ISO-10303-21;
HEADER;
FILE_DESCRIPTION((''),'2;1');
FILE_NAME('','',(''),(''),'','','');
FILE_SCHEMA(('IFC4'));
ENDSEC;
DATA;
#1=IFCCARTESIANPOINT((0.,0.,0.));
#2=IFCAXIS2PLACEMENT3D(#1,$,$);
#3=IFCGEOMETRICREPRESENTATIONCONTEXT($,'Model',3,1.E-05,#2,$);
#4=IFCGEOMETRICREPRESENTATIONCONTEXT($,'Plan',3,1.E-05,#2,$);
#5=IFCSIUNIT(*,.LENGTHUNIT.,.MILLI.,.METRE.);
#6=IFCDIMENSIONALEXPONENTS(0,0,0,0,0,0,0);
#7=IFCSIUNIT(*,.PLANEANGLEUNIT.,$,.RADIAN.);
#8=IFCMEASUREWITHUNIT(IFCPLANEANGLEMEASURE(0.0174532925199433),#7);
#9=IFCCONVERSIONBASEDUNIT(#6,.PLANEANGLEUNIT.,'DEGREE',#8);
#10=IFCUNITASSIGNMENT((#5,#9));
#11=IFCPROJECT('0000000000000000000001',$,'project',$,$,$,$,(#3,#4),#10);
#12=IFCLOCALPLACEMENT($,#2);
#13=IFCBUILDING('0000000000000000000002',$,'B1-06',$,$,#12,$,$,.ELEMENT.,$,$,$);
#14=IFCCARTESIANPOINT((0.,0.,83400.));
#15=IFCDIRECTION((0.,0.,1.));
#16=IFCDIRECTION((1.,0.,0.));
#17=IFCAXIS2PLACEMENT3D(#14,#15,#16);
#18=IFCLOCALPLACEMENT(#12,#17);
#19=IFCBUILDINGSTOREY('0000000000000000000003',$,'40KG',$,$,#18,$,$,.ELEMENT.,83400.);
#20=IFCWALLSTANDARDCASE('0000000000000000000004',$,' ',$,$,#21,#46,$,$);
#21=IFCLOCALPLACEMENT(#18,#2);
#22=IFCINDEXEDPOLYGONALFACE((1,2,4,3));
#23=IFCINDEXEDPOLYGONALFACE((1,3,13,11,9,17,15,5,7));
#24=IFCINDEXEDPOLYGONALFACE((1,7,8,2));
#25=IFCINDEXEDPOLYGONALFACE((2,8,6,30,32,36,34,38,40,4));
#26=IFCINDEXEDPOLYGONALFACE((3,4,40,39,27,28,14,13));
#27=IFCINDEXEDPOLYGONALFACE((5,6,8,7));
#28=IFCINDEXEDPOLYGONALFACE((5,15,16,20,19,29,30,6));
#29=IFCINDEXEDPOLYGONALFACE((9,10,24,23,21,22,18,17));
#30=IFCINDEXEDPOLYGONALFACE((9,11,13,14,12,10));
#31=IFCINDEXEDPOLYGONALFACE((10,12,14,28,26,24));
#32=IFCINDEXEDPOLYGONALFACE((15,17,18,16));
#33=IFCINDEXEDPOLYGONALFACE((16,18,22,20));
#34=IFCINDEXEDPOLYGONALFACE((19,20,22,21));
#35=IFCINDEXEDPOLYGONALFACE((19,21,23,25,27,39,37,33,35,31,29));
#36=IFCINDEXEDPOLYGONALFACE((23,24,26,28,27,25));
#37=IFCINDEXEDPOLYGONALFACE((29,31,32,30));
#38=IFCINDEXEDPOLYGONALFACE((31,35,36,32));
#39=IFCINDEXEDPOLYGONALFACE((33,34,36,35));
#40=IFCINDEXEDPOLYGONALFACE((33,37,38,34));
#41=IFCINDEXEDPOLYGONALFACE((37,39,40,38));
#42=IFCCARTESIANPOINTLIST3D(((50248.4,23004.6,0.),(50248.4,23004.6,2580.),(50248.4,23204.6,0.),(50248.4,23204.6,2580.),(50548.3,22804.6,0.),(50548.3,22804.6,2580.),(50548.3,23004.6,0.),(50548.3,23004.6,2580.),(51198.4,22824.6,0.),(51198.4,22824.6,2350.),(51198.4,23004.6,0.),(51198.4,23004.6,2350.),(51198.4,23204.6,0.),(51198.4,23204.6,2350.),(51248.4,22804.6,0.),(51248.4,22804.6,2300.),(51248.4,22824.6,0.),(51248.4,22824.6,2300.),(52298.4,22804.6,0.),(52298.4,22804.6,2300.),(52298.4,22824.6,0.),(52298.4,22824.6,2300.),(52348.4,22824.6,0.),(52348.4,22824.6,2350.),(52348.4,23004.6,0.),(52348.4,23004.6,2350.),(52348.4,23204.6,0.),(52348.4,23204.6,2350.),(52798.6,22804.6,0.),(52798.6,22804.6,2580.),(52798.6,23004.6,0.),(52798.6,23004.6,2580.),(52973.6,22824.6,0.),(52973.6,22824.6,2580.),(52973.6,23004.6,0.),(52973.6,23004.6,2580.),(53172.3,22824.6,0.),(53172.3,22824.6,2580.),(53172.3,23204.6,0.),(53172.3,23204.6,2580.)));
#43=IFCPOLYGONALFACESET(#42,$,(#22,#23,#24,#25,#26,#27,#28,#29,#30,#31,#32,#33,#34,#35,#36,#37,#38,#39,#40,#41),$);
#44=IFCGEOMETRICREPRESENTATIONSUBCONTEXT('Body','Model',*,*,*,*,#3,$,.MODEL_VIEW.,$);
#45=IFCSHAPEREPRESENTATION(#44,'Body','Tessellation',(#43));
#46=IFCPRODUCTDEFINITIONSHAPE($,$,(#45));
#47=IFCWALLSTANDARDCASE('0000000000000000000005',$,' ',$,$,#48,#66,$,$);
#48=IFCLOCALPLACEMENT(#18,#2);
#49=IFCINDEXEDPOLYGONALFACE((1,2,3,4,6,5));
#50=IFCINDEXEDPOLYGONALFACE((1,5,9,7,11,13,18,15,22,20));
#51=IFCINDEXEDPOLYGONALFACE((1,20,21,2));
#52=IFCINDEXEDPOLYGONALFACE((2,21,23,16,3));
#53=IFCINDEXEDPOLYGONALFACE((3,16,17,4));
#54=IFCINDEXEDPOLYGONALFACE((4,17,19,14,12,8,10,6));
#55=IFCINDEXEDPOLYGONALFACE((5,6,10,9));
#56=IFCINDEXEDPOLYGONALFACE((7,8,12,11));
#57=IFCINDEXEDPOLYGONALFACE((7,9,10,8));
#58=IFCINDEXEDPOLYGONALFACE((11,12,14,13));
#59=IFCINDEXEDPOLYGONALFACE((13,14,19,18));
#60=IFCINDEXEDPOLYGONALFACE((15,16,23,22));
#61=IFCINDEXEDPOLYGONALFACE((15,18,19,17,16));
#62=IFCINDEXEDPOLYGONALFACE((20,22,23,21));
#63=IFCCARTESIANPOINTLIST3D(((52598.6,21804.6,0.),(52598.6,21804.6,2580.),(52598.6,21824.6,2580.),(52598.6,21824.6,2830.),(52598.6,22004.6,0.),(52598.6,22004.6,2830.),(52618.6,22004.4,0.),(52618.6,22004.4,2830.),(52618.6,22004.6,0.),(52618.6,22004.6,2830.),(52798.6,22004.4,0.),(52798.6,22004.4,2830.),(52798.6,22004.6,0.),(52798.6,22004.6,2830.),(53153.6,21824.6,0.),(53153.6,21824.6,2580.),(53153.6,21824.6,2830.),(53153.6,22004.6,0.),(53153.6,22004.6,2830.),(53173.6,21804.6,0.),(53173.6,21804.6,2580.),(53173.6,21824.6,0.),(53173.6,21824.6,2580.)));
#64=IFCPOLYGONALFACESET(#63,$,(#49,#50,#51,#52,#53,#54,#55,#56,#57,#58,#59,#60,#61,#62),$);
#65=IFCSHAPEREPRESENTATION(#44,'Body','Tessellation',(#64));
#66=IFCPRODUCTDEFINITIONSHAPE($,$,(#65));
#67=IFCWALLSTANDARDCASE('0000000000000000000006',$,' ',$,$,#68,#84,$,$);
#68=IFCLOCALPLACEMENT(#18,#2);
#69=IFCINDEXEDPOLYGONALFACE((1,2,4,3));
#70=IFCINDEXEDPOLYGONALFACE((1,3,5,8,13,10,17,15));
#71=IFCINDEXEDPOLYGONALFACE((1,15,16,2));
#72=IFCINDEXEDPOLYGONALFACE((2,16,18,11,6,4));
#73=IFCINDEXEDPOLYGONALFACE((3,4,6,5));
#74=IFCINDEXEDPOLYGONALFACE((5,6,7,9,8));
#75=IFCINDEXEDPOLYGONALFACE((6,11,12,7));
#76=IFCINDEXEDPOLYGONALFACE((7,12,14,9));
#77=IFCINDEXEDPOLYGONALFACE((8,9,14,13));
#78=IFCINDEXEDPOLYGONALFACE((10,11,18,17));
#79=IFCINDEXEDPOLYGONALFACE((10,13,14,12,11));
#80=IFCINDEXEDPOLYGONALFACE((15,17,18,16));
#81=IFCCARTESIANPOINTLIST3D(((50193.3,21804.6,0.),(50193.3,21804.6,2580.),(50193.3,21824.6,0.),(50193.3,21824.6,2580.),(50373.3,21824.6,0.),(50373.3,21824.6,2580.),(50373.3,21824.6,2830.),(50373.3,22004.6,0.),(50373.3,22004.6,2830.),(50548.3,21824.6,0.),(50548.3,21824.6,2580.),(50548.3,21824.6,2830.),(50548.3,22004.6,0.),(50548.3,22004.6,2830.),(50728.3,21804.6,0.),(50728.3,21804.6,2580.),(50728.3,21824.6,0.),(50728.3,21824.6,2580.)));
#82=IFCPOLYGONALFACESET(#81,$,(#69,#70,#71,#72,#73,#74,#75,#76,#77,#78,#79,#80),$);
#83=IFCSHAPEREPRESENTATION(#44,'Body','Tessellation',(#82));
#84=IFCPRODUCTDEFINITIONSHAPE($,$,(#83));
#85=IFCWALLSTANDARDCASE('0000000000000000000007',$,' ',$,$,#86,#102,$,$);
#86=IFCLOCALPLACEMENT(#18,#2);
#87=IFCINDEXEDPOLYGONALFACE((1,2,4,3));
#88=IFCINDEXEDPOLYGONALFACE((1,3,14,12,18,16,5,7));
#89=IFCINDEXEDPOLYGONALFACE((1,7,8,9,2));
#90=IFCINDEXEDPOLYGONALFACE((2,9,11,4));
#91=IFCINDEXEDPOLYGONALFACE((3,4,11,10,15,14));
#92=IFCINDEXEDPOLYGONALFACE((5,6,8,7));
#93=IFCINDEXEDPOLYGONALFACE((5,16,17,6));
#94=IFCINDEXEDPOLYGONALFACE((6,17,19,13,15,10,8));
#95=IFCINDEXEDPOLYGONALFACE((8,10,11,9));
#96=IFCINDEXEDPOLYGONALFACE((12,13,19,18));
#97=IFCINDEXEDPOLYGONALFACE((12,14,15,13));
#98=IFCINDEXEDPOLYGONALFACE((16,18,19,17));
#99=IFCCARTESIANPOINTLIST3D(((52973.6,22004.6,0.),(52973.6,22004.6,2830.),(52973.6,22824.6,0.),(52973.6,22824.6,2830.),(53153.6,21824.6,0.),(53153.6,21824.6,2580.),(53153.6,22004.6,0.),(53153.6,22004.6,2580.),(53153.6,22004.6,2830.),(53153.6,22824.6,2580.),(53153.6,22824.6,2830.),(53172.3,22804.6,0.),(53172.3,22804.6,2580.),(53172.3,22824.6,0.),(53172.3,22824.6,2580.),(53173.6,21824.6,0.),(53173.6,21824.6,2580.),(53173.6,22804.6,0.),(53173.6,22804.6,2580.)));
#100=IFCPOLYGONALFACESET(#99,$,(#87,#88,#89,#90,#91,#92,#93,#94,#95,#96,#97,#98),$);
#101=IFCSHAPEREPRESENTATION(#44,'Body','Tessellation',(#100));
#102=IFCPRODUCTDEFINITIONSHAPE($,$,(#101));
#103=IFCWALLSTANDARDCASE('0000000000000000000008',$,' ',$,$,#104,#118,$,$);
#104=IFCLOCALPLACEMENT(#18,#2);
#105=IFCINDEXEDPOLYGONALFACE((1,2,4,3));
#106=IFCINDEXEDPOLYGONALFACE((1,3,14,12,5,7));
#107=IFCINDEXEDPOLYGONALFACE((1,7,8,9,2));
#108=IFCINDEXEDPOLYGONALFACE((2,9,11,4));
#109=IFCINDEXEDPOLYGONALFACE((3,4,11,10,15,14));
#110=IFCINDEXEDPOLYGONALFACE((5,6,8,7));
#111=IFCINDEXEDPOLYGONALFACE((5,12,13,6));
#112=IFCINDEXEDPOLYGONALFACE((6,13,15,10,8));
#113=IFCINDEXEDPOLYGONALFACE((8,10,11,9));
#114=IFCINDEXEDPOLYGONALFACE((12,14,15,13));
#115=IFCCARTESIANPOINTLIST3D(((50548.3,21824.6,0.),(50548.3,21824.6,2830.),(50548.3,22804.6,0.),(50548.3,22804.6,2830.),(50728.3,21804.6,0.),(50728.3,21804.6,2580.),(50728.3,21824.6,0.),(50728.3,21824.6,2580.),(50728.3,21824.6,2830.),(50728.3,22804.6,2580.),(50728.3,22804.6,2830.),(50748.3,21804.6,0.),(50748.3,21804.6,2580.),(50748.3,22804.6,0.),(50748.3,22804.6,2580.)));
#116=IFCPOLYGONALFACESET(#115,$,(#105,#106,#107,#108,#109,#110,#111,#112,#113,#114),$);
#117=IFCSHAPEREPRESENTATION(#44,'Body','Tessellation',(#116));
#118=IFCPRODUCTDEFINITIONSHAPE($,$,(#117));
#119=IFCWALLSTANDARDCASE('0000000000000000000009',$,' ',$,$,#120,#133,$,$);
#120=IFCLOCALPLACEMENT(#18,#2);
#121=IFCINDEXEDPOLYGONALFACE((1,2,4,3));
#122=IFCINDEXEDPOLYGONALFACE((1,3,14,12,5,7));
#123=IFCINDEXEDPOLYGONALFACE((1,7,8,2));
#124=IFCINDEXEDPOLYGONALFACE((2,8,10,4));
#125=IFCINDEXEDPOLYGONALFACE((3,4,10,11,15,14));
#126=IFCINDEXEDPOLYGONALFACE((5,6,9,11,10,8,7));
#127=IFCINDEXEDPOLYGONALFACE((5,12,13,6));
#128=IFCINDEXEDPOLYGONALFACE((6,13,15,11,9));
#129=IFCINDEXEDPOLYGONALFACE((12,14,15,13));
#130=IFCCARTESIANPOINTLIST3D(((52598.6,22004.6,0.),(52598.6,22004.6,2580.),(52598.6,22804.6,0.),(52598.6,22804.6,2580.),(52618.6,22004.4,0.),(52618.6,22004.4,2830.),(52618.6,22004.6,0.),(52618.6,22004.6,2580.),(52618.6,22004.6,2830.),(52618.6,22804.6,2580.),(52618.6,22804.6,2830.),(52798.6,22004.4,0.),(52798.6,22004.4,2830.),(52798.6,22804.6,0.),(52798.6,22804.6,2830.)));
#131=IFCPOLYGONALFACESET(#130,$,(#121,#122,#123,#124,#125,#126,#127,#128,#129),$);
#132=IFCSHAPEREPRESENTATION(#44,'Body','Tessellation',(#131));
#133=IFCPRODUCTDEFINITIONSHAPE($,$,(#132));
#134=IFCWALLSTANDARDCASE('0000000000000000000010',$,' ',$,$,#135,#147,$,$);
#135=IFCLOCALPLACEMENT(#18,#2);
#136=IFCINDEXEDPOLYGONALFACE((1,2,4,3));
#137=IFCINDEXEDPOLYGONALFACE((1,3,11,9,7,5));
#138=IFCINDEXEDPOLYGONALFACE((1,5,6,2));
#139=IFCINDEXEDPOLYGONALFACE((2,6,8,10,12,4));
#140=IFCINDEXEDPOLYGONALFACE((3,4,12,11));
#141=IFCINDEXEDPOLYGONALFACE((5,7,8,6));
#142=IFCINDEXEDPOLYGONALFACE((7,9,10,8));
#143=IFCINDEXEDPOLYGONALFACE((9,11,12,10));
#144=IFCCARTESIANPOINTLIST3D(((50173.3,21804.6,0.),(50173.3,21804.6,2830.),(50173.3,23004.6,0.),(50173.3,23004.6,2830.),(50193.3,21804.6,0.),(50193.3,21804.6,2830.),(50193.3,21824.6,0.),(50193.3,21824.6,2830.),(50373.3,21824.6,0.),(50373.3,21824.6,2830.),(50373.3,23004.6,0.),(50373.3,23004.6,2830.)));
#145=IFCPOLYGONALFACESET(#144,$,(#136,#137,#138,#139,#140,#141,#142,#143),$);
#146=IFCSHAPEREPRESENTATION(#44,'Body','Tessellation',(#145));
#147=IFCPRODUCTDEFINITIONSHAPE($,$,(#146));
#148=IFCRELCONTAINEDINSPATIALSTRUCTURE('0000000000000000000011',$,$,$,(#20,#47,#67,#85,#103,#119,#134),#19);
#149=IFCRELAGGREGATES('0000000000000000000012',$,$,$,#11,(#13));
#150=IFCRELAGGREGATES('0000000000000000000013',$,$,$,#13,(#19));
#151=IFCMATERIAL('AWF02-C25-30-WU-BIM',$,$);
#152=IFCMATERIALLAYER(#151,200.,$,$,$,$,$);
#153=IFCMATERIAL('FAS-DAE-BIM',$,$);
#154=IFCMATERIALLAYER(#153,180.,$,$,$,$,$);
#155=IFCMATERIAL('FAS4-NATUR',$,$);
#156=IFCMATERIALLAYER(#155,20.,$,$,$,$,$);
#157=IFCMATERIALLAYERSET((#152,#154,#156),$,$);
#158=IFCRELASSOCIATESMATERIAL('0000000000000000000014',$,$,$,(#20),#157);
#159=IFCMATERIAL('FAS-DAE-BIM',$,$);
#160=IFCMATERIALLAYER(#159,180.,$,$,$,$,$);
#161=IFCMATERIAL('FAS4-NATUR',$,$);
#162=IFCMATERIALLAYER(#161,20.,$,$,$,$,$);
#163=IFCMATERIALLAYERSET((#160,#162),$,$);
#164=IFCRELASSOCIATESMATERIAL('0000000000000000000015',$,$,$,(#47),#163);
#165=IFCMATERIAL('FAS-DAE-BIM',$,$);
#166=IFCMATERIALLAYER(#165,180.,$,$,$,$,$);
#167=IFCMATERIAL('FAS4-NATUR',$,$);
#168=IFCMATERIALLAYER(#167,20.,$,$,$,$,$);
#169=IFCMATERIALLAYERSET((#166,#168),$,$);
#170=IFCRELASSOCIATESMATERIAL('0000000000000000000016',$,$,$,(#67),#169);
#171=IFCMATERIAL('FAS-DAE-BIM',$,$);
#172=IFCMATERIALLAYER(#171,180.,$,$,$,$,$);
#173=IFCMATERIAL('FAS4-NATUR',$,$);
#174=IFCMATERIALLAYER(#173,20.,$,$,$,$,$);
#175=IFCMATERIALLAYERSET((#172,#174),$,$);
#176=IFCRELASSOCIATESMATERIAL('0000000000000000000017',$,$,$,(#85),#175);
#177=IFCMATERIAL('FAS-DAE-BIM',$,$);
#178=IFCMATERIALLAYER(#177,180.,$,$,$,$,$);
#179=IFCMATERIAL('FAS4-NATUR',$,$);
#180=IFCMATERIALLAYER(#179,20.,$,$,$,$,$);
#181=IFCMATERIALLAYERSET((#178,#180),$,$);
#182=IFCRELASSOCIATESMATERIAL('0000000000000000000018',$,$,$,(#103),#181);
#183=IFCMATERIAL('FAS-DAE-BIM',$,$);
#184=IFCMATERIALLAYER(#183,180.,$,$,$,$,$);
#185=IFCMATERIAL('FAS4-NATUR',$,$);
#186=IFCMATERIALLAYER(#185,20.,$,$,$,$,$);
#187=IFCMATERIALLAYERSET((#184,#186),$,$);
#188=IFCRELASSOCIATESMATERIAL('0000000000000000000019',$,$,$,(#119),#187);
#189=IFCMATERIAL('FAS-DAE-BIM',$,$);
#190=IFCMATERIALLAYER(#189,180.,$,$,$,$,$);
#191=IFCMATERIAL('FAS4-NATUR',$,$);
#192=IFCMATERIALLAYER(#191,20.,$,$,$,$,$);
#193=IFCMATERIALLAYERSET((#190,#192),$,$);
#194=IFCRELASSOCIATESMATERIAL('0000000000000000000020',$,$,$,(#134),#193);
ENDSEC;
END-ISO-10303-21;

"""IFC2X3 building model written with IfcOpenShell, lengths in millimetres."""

from ifc_helpers import new_model, entity, si_unit, converted_unit, frame, frame_2d, origin, origin_with_axes, place, context, subcontext, project, spatial, polyline, rectangle, outline, extrude, clip, bounded_halfspace, material, layer, layer_set, layer_usage, element, save


model = new_model("IFC2X3")

# Units and contexts
model_context = context("Model", 3, precision=1e-05, world=origin())
plan_context = context("Plan", 3, precision=1e-05, world=origin())
body_context = subcontext(model_context, "Body", "Model", "MODEL_VIEW")
ifc_project = project(units=[si_unit("LENGTHUNIT", "METRE", prefix="MILLI"), converted_unit("PLANEANGLEUNIT", "DEGREE", entity("IfcPlaneAngleMeasure", 0.0174532925199433), si_unit("PLANEANGLEUNIT", "RADIAN"), dimensions=[0, 0, 0, 0, 0, 0, 0])], contexts=[model_context, plan_context])

# Building, storey
building_placement = place(None, origin())
building = spatial("IfcBuilding", under=ifc_project, at=building_placement, Name="B1-06", CompositionType="ELEMENT")
storey_placement = place(building_placement, frame((0.0, 0.0, 83400.0), z_axis=(0.0, 0.0, 1.0), x_axis=(1.0, 0.0, 0.0)))
storey = spatial("IfcBuildingStorey", under=building, at=storey_placement, Name="40KG", CompositionType="ELEMENT", Elevation=83400.0)

# Wall, opening
ifc_material_1 = material(Name="AWF02-C25-30-WU-BIM")
ifc_layer_1 = layer(ifc_material_1, 200.0)
ifc_material_2 = material(Name="FAS-DAE-BIM")
ifc_layer_2 = layer(ifc_material_2, 180.0)
ifc_material_3 = material(Name="FAS4-NATUR")
ifc_layer_3 = layer(ifc_material_3, 20.0)
ifc_layer_set_1 = layer_set([ifc_layer_1, ifc_layer_2, ifc_layer_3])
ifc_layer_usage_1 = layer_usage(ifc_layer_set_1, "AXIS2", "POSITIVE", 0.0)
wall_1_placement = place(storey_placement, frame((53172.3, 23204.6, 0.0), z_axis=(0.0, 0.0, 1.0), x_axis=(-1.0, 0.0, 0.0)))
wall_1 = element("IfcWallStandardCase", 1, at=wall_1_placement, inside=storey, material=ifc_layer_usage_1, Name=" ", context=body_context, shape_type="SweptSolid", body=[
    extrude(outline(polyline([(0.0, 0.0), (2923.9, 0.0), (2923.9, 200.0), (2623.9, 200.0), (2623.9, 400.0), (373.7, 400.0), (373.7, 200.0), (198.7, 200.0), (198.7, 380.0), (0.0, 380.0), (0.0, 0.0)])), origin_with_axes(), (0.0, 0.0, 1.0), 2580.0),
])
opening_1_placement = place(wall_1_placement, frame((823.9, 0.0, 0.0), z_axis=(0.0, 1.0, 0.0), x_axis=(0.0, 0.0, 1.0)))
element("IfcOpeningElement", 2, at=opening_1_placement, cuts=wall_1, ObjectType="Opening", context=body_context, shape_type="SweptSolid", body=[
    extrude(rectangle(XDim=2350.0, YDim=1150.0, at=frame_2d((1175.0, 575.0), x_axis=(1.0, 0.0))), origin_with_axes(), (0.0, 0.0, 1.0), 200.0),
    extrude(rectangle(XDim=2350.0, YDim=1150.0, at=frame_2d((1175.0, 575.0), x_axis=(1.0, 0.0))), frame((0.0, 0.0, 200.0), z_axis=(0.0, 0.0, 1.0), x_axis=(1.0, 0.0, 0.0)), (0.0, 0.0, 1.0), 180.0),
    extrude(rectangle(XDim=2300.0, YDim=1050.0, at=frame_2d((1150.0, 525.0), x_axis=(1.0, 0.0))), frame((0.0, 50.0, 380.0), z_axis=(0.0, 0.0, 1.0), x_axis=(1.0, 0.0, 0.0)), (0.0, 0.0, 1.0), 20.0),
])

# Walls
ifc_material_4 = material(Name="FAS-DAE-BIM")
ifc_layer_4 = layer(ifc_material_4, 180.0)
ifc_material_5 = material(Name="FAS4-NATUR")
ifc_layer_5 = layer(ifc_material_5, 20.0)
ifc_layer_set_2 = layer_set([ifc_layer_4, ifc_layer_5])
ifc_layer_usage_2 = layer_usage(ifc_layer_set_2, "AXIS2", "POSITIVE", 0.0)
wall_2_placement = place(storey_placement, frame((53153.6, 22004.6, 0.0), z_axis=(0.0, 0.0, 1.0), x_axis=(-1.0, 0.0, 0.0)))
element("IfcWallStandardCase", 3, at=wall_2_placement, inside=storey, material=ifc_layer_usage_2, Name=" ", context=body_context, shape_type="Clipping", body=[
    clip(clip(extrude(outline(polyline([(-20.0, 200.0), (-20.0, 180.0), (0.0, 180.0), (0.0, 0.0), (355.0, 0.0), (355.0, 0.2), (535.0, 0.2), (535.0, 0.0), (555.0, 0.0), (555.0, 200.0), (-20.0, 200.0)])), origin_with_axes(), (0.0, 0.0, 1.0), 2830.0), bounded_halfspace(frame((0.0, 0.0, 2830.0), z_axis=(0.0, 0.0, -1.0), x_axis=(1.0, 0.0, 0.0)), True, origin(), polyline([(0.0, 0.0), (355.0, 0.0), (355.0, 0.2), (535.0, 0.2), (535.0, 0.0), (555.0, 0.0), (555.0, 180.0), (0.0, 180.0), (0.0, 0.0)]))), bounded_halfspace(frame((555.0, 180.0, 2580.0), z_axis=(0.0, 0.0, -1.0), x_axis=(0.0, 1.0, 0.0)), True, origin(), polyline([(555.0, 180.0), (555.0, 200.0), (-20.0, 200.0), (-20.0, 180.0), (0.0, 180.0), (555.0, 180.0)]))),
])
ifc_material_6 = material(Name="FAS-DAE-BIM")
ifc_layer_6 = layer(ifc_material_6, 180.0)
ifc_material_7 = material(Name="FAS4-NATUR")
ifc_layer_7 = layer(ifc_material_7, 20.0)
ifc_layer_set_3 = layer_set([ifc_layer_6, ifc_layer_7])
ifc_layer_usage_3 = layer_usage(ifc_layer_set_3, "AXIS2", "POSITIVE", 0.0)
wall_3_placement = place(storey_placement, frame((50548.3, 22004.6, 0.0), z_axis=(0.0, 0.0, 1.0), x_axis=(-1.0, 0.0, 0.0)))
element("IfcWallStandardCase", 4, at=wall_3_placement, inside=storey, material=ifc_layer_usage_3, Name=" ", context=body_context, shape_type="Clipping", body=[
    clip(clip(extrude(outline(polyline([(0.0, 0.0), (175.0, 0.0), (175.0, 180.0), (355.0, 180.0), (355.0, 200.0), (-180.0, 200.0), (-180.0, 180.0), (0.0, 180.0), (0.0, 0.0)])), origin_with_axes(), (0.0, 0.0, 1.0), 2830.0), bounded_halfspace(frame((0.0, 0.0, 2830.0), z_axis=(0.0, 0.0, -1.0), x_axis=(1.0, 0.0, 0.0)), True, origin(), polyline([(0.0, 0.0), (175.0, 0.0), (175.0, 180.0), (0.0, 180.0), (0.0, 0.0)]))), bounded_halfspace(frame((355.0, 180.0, 2580.0), z_axis=(0.0, 0.0, -1.0), x_axis=(0.0, 1.0, 0.0)), True, origin(), polyline([(355.0, 180.0), (355.0, 200.0), (-180.0, 200.0), (-180.0, 180.0), (0.0, 180.0), (175.0, 180.0), (355.0, 180.0)]))),
])
ifc_material_8 = material(Name="FAS-DAE-BIM")
ifc_layer_8 = layer(ifc_material_8, 180.0)
ifc_material_9 = material(Name="FAS4-NATUR")
ifc_layer_9 = layer(ifc_material_9, 20.0)
ifc_layer_set_4 = layer_set([ifc_layer_8, ifc_layer_9])
ifc_layer_usage_4 = layer_usage(ifc_layer_set_4, "AXIS2", "POSITIVE", 0.0)
wall_4_placement = place(storey_placement, frame((52973.6, 22824.6, 0.0), z_axis=(0.0, 0.0, 1.0), x_axis=(0.0, -1.0, 0.0)))
element("IfcWallStandardCase", 5, at=wall_4_placement, inside=storey, material=ifc_layer_usage_4, Name=" ", context=body_context, shape_type="Clipping", body=[
    clip(clip(extrude(outline(polyline([(0.0, 0.0), (820.0, 0.0), (820.0, 180.0), (1000.0, 180.0), (1000.0, 200.0), (20.0, 200.0), (20.0, 198.7), (0.0, 198.7), (0.0, 0.0)])), origin_with_axes(), (0.0, 0.0, 1.0), 2830.0), bounded_halfspace(frame((0.0, 0.0, 2830.0), z_axis=(0.0, 0.0, -1.0), x_axis=(1.0, 0.0, 0.0)), True, origin(), polyline([(0.0, 0.0), (820.0, 0.0), (820.0, 180.0), (0.0, 180.0), (0.0, 0.0)]))), bounded_halfspace(frame((1000.0, 180.0, 2580.0), z_axis=(0.0, 0.0, -1.0), x_axis=(0.0, 1.0, 0.0)), True, origin(), polyline([(1000.0, 180.0), (1000.0, 200.0), (20.0, 200.0), (20.0, 198.7), (0.0, 198.7), (0.0, 180.0), (820.0, 180.0), (1000.0, 180.0)]))),
])
ifc_material_10 = material(Name="FAS-DAE-BIM")
ifc_layer_10 = layer(ifc_material_10, 180.0)
ifc_material_11 = material(Name="FAS4-NATUR")
ifc_layer_11 = layer(ifc_material_11, 20.0)
ifc_layer_set_5 = layer_set([ifc_layer_10, ifc_layer_11])
ifc_layer_usage_5 = layer_usage(ifc_layer_set_5, "AXIS2", "POSITIVE", 0.0)
wall_5_placement = place(storey_placement, frame((50548.3, 22804.6, 0.0), z_axis=(0.0, 0.0, 1.0), x_axis=(0.0, -1.0, 0.0)))
element("IfcWallStandardCase", 6, at=wall_5_placement, inside=storey, material=ifc_layer_usage_5, Name=" ", context=body_context, shape_type="Clipping", body=[
    clip(clip(extrude(outline(polyline([(0.0, 0.0), (980.0, 0.0), (980.0, 180.0), (1000.0, 180.0), (1000.0, 200.0), (0.0, 200.0), (0.0, 0.0)])), origin_with_axes(), (0.0, 0.0, 1.0), 2830.0), bounded_halfspace(frame((0.0, 0.0, 2830.0), z_axis=(0.0, 0.0, -1.0), x_axis=(1.0, 0.0, 0.0)), True, origin(), polyline([(0.0, 0.0), (980.0, 0.0), (980.0, 180.0), (0.0, 180.0), (0.0, 0.0)]))), bounded_halfspace(frame((0.0, 180.0, 2580.0), z_axis=(0.0, 0.0, -1.0), x_axis=(1.0, 0.0, 0.0)), True, origin(), polyline([(0.0, 180.0), (980.0, 180.0), (1000.0, 180.0), (1000.0, 200.0), (0.0, 200.0), (0.0, 180.0)]))),
])
ifc_material_12 = material(Name="FAS-DAE-BIM")
ifc_layer_12 = layer(ifc_material_12, 180.0)
ifc_material_13 = material(Name="FAS4-NATUR")
ifc_layer_13 = layer(ifc_material_13, 20.0)
ifc_layer_set_6 = layer_set([ifc_layer_12, ifc_layer_13])
ifc_layer_usage_6 = layer_usage(ifc_layer_set_6, "AXIS2", "POSITIVE", 0.0)
wall_6_placement = place(storey_placement, frame((52798.6, 22004.4, 0.0), z_axis=(0.0, 0.0, 1.0), x_axis=(0.0, 1.0, 0.0)))
element("IfcWallStandardCase", 7, at=wall_6_placement, inside=storey, material=ifc_layer_usage_6, Name=" ", context=body_context, shape_type="Clipping", body=[
    clip(clip(extrude(outline(polyline([(0.2, 200.0), (0.2, 180.0), (0.0, 180.0), (0.0, 0.0), (800.2, 0.0), (800.2, 200.0), (0.2, 200.0)])), origin_with_axes(), (0.0, 0.0, 1.0), 2830.0), bounded_halfspace(frame((0.0, 0.0, 2830.0), z_axis=(0.0, 0.0, -1.0), x_axis=(1.0, 0.0, 0.0)), True, origin(), polyline([(0.0, 0.0), (800.2, 0.0), (800.2, 180.0), (0.0, 180.0), (0.0, 0.0)]))), bounded_halfspace(frame((0.2, 180.0, 2580.0), z_axis=(0.0, 0.0, -1.0), x_axis=(1.0, 0.0, 0.0)), True, origin(), polyline([(0.2, 180.0), (800.2, 180.0), (800.2, 200.0), (0.2, 200.0), (0.2, 180.0)]))),
])
ifc_material_14 = material(Name="FAS-DAE-BIM")
ifc_layer_14 = layer(ifc_material_14, 180.0)
ifc_material_15 = material(Name="FAS4-NATUR")
ifc_layer_15 = layer(ifc_material_15, 20.0)
ifc_layer_set_7 = layer_set([ifc_layer_14, ifc_layer_15])
ifc_layer_usage_7 = layer_usage(ifc_layer_set_7, "AXIS2", "POSITIVE", 0.0)
wall_7_placement = place(storey_placement, frame((50373.3, 21824.6, 0.0), z_axis=(0.0, 0.0, 1.0), x_axis=(0.0, 1.0, 0.0)))
element("IfcWallStandardCase", 8, at=wall_7_placement, inside=storey, material=ifc_layer_usage_7, Name=" ", context=body_context, shape_type="SweptSolid", body=[
    extrude(outline(polyline([(-20.0, 200.0), (-20.0, 180.0), (0.0, 180.0), (0.0, 0.0), (1180.0, 0.0), (1180.0, 200.0), (-20.0, 200.0)])), origin_with_axes(), (0.0, 0.0, 1.0), 2830.0),
])

save(model, "model.ifc")
